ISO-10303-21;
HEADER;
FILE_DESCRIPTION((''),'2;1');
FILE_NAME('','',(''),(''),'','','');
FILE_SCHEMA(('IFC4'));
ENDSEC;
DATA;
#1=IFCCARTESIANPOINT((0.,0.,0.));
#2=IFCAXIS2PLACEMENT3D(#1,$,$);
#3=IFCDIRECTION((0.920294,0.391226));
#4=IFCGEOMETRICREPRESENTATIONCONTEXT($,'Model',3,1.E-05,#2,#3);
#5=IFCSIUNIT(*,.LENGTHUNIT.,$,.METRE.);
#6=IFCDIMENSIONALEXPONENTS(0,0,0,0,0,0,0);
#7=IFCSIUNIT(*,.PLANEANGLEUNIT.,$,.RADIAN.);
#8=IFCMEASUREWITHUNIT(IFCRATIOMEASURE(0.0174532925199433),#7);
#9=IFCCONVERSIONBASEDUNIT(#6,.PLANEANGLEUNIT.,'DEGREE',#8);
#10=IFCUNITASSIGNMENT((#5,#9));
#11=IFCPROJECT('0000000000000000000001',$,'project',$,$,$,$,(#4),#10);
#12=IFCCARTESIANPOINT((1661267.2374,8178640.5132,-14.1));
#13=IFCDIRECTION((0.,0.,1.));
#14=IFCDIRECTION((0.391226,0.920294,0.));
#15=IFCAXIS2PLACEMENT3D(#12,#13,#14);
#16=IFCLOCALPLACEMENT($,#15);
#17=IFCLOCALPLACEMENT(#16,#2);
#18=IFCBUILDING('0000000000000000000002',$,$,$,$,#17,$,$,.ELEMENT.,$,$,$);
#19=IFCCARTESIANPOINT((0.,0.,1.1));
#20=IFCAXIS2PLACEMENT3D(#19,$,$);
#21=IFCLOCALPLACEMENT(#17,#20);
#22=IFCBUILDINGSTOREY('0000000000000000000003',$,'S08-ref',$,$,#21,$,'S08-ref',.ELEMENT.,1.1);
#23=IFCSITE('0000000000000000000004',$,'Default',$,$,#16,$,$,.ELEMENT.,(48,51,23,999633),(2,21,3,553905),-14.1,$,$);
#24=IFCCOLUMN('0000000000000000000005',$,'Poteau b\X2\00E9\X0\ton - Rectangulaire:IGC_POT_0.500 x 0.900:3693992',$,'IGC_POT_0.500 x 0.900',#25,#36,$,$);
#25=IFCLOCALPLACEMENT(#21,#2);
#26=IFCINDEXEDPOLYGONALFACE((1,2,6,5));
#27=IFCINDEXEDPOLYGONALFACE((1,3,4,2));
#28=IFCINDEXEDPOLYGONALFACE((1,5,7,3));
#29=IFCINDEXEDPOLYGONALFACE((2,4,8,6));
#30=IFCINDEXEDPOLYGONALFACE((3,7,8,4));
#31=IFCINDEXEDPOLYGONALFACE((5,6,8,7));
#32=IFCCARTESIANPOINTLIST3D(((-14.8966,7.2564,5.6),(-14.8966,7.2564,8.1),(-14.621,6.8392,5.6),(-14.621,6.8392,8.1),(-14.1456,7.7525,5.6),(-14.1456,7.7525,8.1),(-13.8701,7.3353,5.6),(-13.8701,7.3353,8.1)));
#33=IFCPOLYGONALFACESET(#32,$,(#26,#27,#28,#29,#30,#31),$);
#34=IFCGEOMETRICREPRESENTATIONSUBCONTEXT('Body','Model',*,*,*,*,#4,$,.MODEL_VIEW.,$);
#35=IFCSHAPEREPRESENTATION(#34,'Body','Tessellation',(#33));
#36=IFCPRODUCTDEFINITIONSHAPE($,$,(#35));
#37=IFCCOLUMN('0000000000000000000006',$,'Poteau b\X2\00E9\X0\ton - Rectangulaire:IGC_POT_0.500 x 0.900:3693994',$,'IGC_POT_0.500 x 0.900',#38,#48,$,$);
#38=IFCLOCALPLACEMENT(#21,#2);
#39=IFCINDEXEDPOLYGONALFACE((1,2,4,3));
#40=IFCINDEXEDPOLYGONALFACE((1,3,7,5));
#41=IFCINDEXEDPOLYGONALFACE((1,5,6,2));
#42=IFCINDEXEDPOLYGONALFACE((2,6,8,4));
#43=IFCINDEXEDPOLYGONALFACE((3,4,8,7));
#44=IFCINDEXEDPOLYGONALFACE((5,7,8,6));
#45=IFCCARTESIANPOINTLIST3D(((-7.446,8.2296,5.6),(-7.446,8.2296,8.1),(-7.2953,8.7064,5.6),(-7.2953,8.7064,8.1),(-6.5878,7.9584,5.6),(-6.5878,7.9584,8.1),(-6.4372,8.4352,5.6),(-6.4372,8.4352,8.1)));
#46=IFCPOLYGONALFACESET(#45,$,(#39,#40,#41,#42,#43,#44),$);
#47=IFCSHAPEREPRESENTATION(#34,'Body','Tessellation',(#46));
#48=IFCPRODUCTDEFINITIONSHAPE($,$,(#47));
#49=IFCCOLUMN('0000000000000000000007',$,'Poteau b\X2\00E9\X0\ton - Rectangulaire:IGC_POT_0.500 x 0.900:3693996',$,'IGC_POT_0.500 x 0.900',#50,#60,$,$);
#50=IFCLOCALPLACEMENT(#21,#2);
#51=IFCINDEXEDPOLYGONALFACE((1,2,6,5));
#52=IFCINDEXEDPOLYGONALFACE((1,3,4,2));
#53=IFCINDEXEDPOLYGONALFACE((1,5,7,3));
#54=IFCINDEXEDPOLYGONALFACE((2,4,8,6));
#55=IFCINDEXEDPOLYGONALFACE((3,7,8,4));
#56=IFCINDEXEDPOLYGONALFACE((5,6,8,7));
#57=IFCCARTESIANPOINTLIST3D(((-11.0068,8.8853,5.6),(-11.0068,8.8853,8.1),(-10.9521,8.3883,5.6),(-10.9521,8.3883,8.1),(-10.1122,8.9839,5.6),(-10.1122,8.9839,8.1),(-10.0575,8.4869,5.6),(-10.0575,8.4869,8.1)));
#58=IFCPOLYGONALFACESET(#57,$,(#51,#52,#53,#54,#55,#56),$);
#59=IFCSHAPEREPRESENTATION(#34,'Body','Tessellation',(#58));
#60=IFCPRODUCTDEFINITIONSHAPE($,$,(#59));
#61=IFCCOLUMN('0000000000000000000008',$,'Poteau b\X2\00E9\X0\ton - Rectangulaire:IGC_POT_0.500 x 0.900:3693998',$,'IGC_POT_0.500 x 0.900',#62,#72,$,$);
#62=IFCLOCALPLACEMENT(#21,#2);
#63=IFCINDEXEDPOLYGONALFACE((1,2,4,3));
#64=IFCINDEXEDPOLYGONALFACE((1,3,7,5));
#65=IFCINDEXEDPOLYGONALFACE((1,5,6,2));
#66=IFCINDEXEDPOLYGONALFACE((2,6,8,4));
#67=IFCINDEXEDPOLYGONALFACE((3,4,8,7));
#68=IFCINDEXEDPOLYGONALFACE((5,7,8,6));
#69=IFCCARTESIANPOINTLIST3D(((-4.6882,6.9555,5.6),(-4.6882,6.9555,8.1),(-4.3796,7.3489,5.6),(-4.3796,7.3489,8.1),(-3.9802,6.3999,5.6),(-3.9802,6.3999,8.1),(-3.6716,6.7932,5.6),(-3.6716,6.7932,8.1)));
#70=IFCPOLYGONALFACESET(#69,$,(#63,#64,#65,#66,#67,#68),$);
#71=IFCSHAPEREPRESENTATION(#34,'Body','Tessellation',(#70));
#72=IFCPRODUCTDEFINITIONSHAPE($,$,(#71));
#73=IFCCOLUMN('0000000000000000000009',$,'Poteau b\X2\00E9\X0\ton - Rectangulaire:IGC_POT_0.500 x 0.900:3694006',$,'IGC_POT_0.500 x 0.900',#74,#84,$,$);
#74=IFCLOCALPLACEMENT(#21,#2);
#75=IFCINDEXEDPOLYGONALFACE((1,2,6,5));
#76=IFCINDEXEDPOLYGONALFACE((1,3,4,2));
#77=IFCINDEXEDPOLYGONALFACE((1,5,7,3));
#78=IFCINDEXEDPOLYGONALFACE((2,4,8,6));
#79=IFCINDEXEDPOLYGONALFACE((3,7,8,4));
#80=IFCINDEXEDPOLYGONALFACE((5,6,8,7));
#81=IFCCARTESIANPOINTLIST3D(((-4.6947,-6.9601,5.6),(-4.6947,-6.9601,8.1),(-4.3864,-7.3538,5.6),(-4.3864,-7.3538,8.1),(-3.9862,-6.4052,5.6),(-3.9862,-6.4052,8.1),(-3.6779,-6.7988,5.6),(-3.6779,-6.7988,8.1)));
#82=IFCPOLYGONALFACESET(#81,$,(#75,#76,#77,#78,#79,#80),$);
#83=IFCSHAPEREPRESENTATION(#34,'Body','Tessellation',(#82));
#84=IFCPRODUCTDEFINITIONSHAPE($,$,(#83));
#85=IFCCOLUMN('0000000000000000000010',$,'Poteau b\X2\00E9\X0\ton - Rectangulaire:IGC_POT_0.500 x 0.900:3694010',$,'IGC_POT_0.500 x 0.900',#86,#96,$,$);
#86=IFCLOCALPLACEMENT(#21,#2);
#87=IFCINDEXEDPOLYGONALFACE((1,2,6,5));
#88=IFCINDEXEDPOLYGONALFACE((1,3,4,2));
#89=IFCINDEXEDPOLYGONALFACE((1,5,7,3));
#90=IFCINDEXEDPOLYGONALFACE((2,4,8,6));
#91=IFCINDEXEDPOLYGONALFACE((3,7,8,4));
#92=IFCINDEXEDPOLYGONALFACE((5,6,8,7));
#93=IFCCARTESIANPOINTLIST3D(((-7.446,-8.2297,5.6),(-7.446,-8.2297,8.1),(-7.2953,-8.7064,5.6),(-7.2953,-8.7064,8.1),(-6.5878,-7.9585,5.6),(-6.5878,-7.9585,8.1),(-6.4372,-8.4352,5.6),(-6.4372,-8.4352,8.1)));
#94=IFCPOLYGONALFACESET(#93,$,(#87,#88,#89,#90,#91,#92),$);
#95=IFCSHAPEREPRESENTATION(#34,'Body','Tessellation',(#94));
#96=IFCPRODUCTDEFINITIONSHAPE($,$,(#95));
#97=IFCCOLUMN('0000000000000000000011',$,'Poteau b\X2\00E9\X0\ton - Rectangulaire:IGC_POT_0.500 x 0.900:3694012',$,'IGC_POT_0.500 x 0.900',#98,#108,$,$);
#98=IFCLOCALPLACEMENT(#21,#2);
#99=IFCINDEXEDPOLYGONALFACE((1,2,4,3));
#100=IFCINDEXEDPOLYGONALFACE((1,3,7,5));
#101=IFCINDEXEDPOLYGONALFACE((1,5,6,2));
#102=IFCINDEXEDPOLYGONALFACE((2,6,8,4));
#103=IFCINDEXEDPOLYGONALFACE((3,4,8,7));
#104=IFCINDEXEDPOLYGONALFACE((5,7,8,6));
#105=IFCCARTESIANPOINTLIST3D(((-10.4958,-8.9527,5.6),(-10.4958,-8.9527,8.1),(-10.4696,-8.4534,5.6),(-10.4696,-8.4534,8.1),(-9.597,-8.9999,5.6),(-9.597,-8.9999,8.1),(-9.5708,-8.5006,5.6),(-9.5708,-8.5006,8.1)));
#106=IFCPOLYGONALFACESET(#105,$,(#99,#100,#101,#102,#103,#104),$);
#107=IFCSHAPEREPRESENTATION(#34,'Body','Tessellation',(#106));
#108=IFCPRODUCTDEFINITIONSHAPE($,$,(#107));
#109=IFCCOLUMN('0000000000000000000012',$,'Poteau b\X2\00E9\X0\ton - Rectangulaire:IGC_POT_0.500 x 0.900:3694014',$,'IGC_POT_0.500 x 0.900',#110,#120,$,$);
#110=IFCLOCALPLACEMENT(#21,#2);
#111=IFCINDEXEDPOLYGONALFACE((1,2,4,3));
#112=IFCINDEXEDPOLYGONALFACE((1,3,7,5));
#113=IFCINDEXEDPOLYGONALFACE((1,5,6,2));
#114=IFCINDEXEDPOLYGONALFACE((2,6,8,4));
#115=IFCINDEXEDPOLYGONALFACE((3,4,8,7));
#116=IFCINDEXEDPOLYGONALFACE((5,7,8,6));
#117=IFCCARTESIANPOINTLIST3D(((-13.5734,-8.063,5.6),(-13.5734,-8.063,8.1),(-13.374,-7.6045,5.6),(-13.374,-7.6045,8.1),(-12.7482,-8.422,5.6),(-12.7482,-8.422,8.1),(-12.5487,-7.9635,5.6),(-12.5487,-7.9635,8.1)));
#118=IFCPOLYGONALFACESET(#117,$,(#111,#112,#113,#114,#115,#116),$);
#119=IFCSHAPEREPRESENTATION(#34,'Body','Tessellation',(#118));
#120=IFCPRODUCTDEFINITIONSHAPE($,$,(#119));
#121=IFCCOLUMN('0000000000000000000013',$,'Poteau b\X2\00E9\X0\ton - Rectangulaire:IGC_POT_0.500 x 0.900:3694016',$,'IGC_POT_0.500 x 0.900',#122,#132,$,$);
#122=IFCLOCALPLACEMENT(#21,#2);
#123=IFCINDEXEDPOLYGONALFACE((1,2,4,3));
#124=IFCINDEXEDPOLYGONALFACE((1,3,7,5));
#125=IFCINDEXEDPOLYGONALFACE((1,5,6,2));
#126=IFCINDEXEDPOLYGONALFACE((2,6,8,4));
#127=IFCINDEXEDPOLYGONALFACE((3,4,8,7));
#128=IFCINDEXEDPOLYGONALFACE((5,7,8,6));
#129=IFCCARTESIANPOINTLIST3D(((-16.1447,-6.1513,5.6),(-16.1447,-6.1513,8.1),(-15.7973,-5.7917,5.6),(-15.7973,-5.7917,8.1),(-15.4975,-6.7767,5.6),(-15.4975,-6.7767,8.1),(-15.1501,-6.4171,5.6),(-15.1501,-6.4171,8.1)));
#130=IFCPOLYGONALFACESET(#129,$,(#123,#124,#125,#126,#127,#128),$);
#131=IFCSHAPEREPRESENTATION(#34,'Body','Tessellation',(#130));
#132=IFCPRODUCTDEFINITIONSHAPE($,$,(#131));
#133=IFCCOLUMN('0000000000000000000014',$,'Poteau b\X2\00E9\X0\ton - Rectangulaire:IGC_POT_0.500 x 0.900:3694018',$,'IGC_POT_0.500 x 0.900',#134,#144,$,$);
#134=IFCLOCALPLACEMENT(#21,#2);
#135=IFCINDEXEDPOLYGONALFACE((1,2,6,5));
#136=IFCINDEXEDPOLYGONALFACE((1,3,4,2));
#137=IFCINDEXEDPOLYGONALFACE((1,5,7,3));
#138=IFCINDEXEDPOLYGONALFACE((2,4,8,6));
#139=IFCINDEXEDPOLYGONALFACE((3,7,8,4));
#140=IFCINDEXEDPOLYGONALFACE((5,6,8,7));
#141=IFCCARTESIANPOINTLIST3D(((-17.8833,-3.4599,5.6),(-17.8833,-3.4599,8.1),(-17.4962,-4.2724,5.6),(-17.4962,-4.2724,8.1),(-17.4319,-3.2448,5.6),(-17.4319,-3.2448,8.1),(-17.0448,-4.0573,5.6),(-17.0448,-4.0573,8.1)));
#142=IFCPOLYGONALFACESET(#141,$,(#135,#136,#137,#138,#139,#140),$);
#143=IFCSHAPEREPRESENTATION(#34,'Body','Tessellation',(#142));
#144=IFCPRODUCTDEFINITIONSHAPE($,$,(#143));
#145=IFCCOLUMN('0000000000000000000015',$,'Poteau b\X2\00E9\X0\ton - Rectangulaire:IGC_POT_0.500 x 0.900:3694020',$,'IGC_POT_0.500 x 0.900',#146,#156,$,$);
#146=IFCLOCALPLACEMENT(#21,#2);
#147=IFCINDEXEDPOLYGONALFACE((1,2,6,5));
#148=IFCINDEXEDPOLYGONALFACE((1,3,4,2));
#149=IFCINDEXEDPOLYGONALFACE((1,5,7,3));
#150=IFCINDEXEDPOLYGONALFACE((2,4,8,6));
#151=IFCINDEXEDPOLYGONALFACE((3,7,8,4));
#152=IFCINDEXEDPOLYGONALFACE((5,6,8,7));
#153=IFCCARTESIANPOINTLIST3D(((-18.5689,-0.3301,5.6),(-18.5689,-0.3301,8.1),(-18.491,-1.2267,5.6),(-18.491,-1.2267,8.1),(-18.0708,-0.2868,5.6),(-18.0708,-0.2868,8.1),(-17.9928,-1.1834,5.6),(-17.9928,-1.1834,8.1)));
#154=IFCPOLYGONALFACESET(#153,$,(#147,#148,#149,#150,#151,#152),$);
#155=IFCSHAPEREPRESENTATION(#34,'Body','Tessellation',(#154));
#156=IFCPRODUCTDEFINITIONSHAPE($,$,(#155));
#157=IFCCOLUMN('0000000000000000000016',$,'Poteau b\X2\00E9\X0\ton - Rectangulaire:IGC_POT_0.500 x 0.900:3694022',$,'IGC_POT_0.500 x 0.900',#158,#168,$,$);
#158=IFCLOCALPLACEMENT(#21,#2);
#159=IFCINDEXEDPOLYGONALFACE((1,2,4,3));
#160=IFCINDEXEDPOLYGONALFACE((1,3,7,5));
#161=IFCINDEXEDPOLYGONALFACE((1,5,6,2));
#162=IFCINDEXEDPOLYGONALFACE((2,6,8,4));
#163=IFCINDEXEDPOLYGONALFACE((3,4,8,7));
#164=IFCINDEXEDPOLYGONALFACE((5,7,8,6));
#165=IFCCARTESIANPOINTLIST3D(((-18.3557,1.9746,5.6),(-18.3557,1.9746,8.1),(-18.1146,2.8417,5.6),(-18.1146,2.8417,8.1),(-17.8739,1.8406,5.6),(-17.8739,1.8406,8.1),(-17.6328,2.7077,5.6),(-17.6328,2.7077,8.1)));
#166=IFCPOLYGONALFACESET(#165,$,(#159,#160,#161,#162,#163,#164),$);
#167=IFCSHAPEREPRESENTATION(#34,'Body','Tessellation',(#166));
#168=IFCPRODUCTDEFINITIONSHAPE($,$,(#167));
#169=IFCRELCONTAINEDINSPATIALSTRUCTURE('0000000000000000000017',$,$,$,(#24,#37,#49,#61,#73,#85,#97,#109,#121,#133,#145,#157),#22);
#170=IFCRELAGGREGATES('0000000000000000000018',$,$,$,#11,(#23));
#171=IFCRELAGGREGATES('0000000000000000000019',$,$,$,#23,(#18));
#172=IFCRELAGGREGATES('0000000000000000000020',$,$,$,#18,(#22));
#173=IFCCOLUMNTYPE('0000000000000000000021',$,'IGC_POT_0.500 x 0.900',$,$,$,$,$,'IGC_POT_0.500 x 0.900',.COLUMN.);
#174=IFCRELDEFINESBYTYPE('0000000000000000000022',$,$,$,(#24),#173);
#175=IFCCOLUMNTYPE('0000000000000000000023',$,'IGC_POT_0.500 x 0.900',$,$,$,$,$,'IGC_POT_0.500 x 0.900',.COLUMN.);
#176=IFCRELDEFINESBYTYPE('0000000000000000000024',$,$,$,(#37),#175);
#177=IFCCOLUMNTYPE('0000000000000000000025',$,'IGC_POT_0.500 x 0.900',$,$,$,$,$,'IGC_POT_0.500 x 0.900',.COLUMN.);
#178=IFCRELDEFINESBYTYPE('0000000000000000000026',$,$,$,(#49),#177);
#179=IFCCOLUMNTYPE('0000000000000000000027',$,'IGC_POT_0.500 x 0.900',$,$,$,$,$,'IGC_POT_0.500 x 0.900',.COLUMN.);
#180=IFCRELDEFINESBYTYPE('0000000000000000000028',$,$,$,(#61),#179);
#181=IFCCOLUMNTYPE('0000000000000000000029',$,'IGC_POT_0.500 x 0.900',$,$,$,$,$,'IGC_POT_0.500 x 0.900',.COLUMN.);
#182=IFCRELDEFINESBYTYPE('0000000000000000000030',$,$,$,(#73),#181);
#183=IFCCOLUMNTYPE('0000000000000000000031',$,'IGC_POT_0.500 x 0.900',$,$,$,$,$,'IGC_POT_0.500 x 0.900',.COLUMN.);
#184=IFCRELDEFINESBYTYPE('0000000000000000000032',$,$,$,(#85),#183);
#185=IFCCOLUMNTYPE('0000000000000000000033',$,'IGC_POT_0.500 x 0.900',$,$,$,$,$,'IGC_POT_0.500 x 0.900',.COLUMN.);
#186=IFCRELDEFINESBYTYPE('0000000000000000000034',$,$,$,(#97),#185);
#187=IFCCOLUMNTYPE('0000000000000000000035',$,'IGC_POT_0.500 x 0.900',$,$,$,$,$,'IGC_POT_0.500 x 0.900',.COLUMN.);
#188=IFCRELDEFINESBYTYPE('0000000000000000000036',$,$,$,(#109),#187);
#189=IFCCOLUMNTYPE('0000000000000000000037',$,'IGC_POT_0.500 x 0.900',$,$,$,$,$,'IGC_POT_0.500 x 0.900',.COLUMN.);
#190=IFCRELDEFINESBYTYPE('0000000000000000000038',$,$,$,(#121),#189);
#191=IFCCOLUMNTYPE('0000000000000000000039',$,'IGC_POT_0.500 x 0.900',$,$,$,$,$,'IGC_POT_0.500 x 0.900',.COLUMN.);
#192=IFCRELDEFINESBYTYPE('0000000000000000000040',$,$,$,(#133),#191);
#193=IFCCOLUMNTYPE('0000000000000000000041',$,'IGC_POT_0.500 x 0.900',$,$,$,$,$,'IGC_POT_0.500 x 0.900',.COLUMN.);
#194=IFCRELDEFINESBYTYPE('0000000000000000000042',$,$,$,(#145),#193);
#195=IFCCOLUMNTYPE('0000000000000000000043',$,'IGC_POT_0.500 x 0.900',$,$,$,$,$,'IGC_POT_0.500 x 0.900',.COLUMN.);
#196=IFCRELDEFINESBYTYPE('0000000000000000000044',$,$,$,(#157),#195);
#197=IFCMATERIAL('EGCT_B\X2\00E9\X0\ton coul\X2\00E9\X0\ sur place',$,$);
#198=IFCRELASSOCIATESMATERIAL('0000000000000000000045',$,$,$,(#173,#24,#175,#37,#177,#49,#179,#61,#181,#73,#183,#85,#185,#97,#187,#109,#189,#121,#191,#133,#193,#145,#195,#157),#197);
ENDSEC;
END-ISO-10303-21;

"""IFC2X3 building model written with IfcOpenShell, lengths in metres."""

from ifc_helpers import new_model, entity, si_unit, converted_unit, direction, frame, frame_2d, origin, origin_2d_with_axis, place, context, subcontext, project, spatial, rectangle, extrude, source, transform, mapped, material, type_object, type_shapes, element, save


model = new_model("IFC2X3")

# Units and contexts
model_context = context("Model", 3, precision=1e-05, world=origin(), true_north=direction((0.920294, 0.391226)))
body_context = subcontext(model_context, "Body", "Model", "MODEL_VIEW")
ifc_project = project(units=[si_unit("LENGTHUNIT", "METRE"), converted_unit("PLANEANGLEUNIT", "DEGREE", entity("IfcRatioMeasure", 0.0174532925199433), si_unit("PLANEANGLEUNIT", "RADIAN"), dimensions=[0, 0, 0, 0, 0, 0, 0])], contexts=[model_context])

# Site, building, storey
site_placement = place(None, frame((1661267.2374, 8178640.5132, -14.1), z_axis=(0.0, 0.0, 1.0), x_axis=(0.391226, 0.920294, 0.0)))
site = spatial("IfcSite", under=ifc_project, at=site_placement, Name="Default", CompositionType="ELEMENT", RefLatitude=(48, 51, 23, 999633), RefLongitude=(2, 21, 3, 553905), RefElevation=-14.1)
building_placement = place(site_placement, origin())
building = spatial("IfcBuilding", under=site, at=building_placement, CompositionType="ELEMENT")
storey_placement = place(building_placement, frame((0.0, 0.0, 1.1)))
storey = spatial("IfcBuildingStorey", under=building, at=storey_placement, Name="S08-ref", LongName="S08-ref", CompositionType="ELEMENT", Elevation=1.1)

# Columns
ifc_material_1 = material(Name="EGCT_Béton coulé sur place")
column_type_1 = type_object("IfcColumnType", Name="IGC_POT_0.500 x 0.900", ElementType="IGC_POT_0.500 x 0.900", PredefinedType="COLUMN", material=ifc_material_1)
shared_shape_1 = source(origin(), body_context, "Body", "SweptSolid", [
    extrude(rectangle(XDim=0.5, YDim=0.9, at=origin_2d_with_axis()), frame((-14.3833, 7.2959, 6.7), z_axis=(0.0, 0.0, 1.0), x_axis=(-0.551164, 0.834397, 0.0)), (0.0, 0.0, 1.0), 2.5),
])
type_shapes(column_type_1, [shared_shape_1])
column_1_placement = place(storey_placement, frame((0.0, 0.0, -1.1)))
element("IfcColumn", 1, at=column_1_placement, inside=storey, type_object=column_type_1, material=ifc_material_1, Name="Poteau béton - Rectangulaire:IGC_POT_0.500 x 0.900:3693992", ObjectType="IGC_POT_0.500 x 0.900", context=body_context, shape_type="MappedRepresentation", body=[
    mapped(shared_shape_1, transform((0.0, 0.0, 0.0), scale=1.0)),
])
column_type_2 = type_object("IfcColumnType", Name="IGC_POT_0.500 x 0.900", ElementType="IGC_POT_0.500 x 0.900", PredefinedType="COLUMN", material=ifc_material_1)
shared_shape_2 = source(origin(), body_context, "Body", "SweptSolid", [
    extrude(rectangle(XDim=0.9, YDim=0.5, at=origin_2d_with_axis()), frame((-6.9416, 8.3324, 6.7), z_axis=(0.0, 0.0, 1.0), x_axis=(-0.953513, 0.301352, 0.0)), (0.0, 0.0, 1.0), 2.5),
])
type_shapes(column_type_2, [shared_shape_2])
column_2_placement = place(storey_placement, frame((0.0, 0.0, -1.1)))
element("IfcColumn", 2, at=column_2_placement, inside=storey, type_object=column_type_2, material=ifc_material_1, Name="Poteau béton - Rectangulaire:IGC_POT_0.500 x 0.900:3693994", ObjectType="IGC_POT_0.500 x 0.900", context=body_context, shape_type="MappedRepresentation", body=[
    mapped(shared_shape_2, transform((0.0, 0.0, 0.0), scale=1.0)),
])
column_type_3 = type_object("IfcColumnType", Name="IGC_POT_0.500 x 0.900", ElementType="IGC_POT_0.500 x 0.900", PredefinedType="COLUMN", material=ifc_material_1)
shared_shape_3 = source(origin(), body_context, "Body", "SweptSolid", [
    extrude(rectangle(XDim=0.9, YDim=0.5, at=frame_2d((0.0, 0.0), x_axis=(1.0, 0.0))), frame((-10.5321, 8.6861, 6.7), z_axis=(0.0, 0.0, 1.0), x_axis=(-0.993983, -0.10953, 0.0)), (0.0, 0.0, 1.0), 2.5),
])
type_shapes(column_type_3, [shared_shape_3])
column_3_placement = place(storey_placement, frame((0.0, 0.0, -1.1)))
element("IfcColumn", 3, at=column_3_placement, inside=storey, type_object=column_type_3, material=ifc_material_1, Name="Poteau béton - Rectangulaire:IGC_POT_0.500 x 0.900:3693996", ObjectType="IGC_POT_0.500 x 0.900", context=body_context, shape_type="MappedRepresentation", body=[
    mapped(shared_shape_3, transform((0.0, 0.0, 0.0), scale=1.0)),
])
column_type_4 = type_object("IfcColumnType", Name="IGC_POT_0.500 x 0.900", ElementType="IGC_POT_0.500 x 0.900", PredefinedType="COLUMN", material=ifc_material_1)
shared_shape_4 = source(origin(), body_context, "Body", "SweptSolid", [
    extrude(rectangle(XDim=0.9, YDim=0.5, at=frame_2d((0.0, 0.0), x_axis=(1.0, 0.0))), frame((-4.1799, 6.8744, 6.7), z_axis=(0.0, 0.0, 1.0), x_axis=(-0.786665, 0.617381, 0.0)), (0.0, 0.0, 1.0), 2.5),
])
type_shapes(column_type_4, [shared_shape_4])
column_4_placement = place(storey_placement, frame((0.0, 0.0, -1.1)))
element("IfcColumn", 4, at=column_4_placement, inside=storey, type_object=column_type_4, material=ifc_material_1, Name="Poteau béton - Rectangulaire:IGC_POT_0.500 x 0.900:3693998", ObjectType="IGC_POT_0.500 x 0.900", context=body_context, shape_type="MappedRepresentation", body=[
    mapped(shared_shape_4, transform((0.0, 0.0, 0.0), scale=1.0)),
])
column_type_5 = type_object("IfcColumnType", Name="IGC_POT_0.500 x 0.900", ElementType="IGC_POT_0.500 x 0.900", PredefinedType="COLUMN", material=ifc_material_1)
shared_shape_5 = source(origin(), body_context, "Body", "SweptSolid", [
    extrude(rectangle(XDim=0.9, YDim=0.5, at=origin_2d_with_axis()), frame((-4.1863, -6.8795, 6.7), z_axis=(0.0, 0.0, 1.0), x_axis=(0.787239, 0.616648, 0.0)), (0.0, 0.0, 1.0), 2.5),
])
type_shapes(column_type_5, [shared_shape_5])
column_5_placement = place(storey_placement, frame((0.0, 0.0, -1.1)))
element("IfcColumn", 5, at=column_5_placement, inside=storey, type_object=column_type_5, material=ifc_material_1, Name="Poteau béton - Rectangulaire:IGC_POT_0.500 x 0.900:3694006", ObjectType="IGC_POT_0.500 x 0.900", context=body_context, shape_type="MappedRepresentation", body=[
    mapped(shared_shape_5, transform((0.0, 0.0, 0.0), scale=1.0)),
])
column_type_6 = type_object("IfcColumnType", Name="IGC_POT_0.500 x 0.900", ElementType="IGC_POT_0.500 x 0.900", PredefinedType="COLUMN", material=ifc_material_1)
shared_shape_6 = source(origin(), body_context, "Body", "SweptSolid", [
    extrude(rectangle(XDim=0.5, YDim=0.9, at=origin_2d_with_axis()), frame((-6.9416, -8.3325, 6.7), z_axis=(0.0, 0.0, 1.0), x_axis=(-0.301353, 0.953513, 0.0)), (0.0, 0.0, 1.0), 2.5),
])
type_shapes(column_type_6, [shared_shape_6])
column_6_placement = place(storey_placement, frame((0.0, 0.0, -1.1)))
element("IfcColumn", 6, at=column_6_placement, inside=storey, type_object=column_type_6, material=ifc_material_1, Name="Poteau béton - Rectangulaire:IGC_POT_0.500 x 0.900:3694010", ObjectType="IGC_POT_0.500 x 0.900", context=body_context, shape_type="MappedRepresentation", body=[
    mapped(shared_shape_6, transform((0.0, 0.0, 0.0), scale=1.0)),
])
column_type_7 = type_object("IfcColumnType", Name="IGC_POT_0.500 x 0.900", ElementType="IGC_POT_0.500 x 0.900", PredefinedType="COLUMN", material=ifc_material_1)
shared_shape_7 = source(origin(), body_context, "Body", "SweptSolid", [
    extrude(rectangle(XDim=0.5, YDim=0.9, at=frame_2d((0.0, 0.0), x_axis=(1.0, 0.0))), frame((-10.0333, -8.7267, 6.7), z_axis=(0.0, 0.0, 1.0), x_axis=(0.052447, 0.998624, 0.0)), (0.0, 0.0, 1.0), 2.5),
])
type_shapes(column_type_7, [shared_shape_7])
column_7_placement = place(storey_placement, frame((0.0, 0.0, -1.1)))
element("IfcColumn", 7, at=column_7_placement, inside=storey, type_object=column_type_7, material=ifc_material_1, Name="Poteau béton - Rectangulaire:IGC_POT_0.500 x 0.900:3694012", ObjectType="IGC_POT_0.500 x 0.900", context=body_context, shape_type="MappedRepresentation", body=[
    mapped(shared_shape_7, transform((0.0, 0.0, 0.0), scale=1.0)),
])
column_type_8 = type_object("IfcColumnType", Name="IGC_POT_0.500 x 0.900", ElementType="IGC_POT_0.500 x 0.900", PredefinedType="COLUMN", material=ifc_material_1)
shared_shape_8 = source(origin(), body_context, "Body", "SweptSolid", [
    extrude(rectangle(XDim=0.9, YDim=0.5, at=frame_2d((0.0, 0.0), x_axis=(1.0, 0.0))), frame((-13.0611, -8.0132, 6.7), z_axis=(0.0, 0.0, 1.0), x_axis=(-0.916984, 0.398923, 0.0)), (0.0, 0.0, 1.0), 2.5),
])
type_shapes(column_type_8, [shared_shape_8])
column_8_placement = place(storey_placement, frame((0.0, 0.0, -1.1)))
element("IfcColumn", 8, at=column_8_placement, inside=storey, type_object=column_type_8, material=ifc_material_1, Name="Poteau béton - Rectangulaire:IGC_POT_0.500 x 0.900:3694014", ObjectType="IGC_POT_0.500 x 0.900", context=body_context, shape_type="MappedRepresentation", body=[
    mapped(shared_shape_8, transform((0.0, 0.0, 0.0), scale=1.0)),
])
column_type_9 = type_object("IfcColumnType", Name="IGC_POT_0.500 x 0.900", ElementType="IGC_POT_0.500 x 0.900", PredefinedType="COLUMN", material=ifc_material_1)
shared_shape_9 = source(origin(), body_context, "Body", "SweptSolid", [
    extrude(rectangle(XDim=0.9, YDim=0.5, at=origin_2d_with_axis()), frame((-15.6474, -6.2842, 6.7), z_axis=(0.0, 0.0, 1.0), x_axis=(-0.719121, 0.694885, 0.0)), (0.0, 0.0, 1.0), 2.5),
])
type_shapes(column_type_9, [shared_shape_9])
column_9_placement = place(storey_placement, frame((0.0, 0.0, -1.1)))
element("IfcColumn", 9, at=column_9_placement, inside=storey, type_object=column_type_9, material=ifc_material_1, Name="Poteau béton - Rectangulaire:IGC_POT_0.500 x 0.900:3694016", ObjectType="IGC_POT_0.500 x 0.900", context=body_context, shape_type="MappedRepresentation", body=[
    mapped(shared_shape_9, transform((0.0, 0.0, 0.0), scale=1.0)),
])
column_type_10 = type_object("IfcColumnType", Name="IGC_POT_0.500 x 0.900", ElementType="IGC_POT_0.500 x 0.900", PredefinedType="COLUMN", material=ifc_material_1)
shared_shape_10 = source(origin(), body_context, "Body", "SweptSolid", [
    extrude(rectangle(XDim=0.9, YDim=0.5, at=frame_2d((0.0, 0.0), x_axis=(1.0, 0.0))), frame((-17.4641, -3.7586, 6.7), z_axis=(0.0, 0.0, 1.0), x_axis=(-0.430108, 0.902777, 0.0)), (0.0, 0.0, 1.0), 2.5),
])
type_shapes(column_type_10, [shared_shape_10])
column_10_placement = place(storey_placement, frame((0.0, 0.0, -1.1)))
element("IfcColumn", 10, at=column_10_placement, inside=storey, type_object=column_type_10, material=ifc_material_1, Name="Poteau béton - Rectangulaire:IGC_POT_0.500 x 0.900:3694018", ObjectType="IGC_POT_0.500 x 0.900", context=body_context, shape_type="MappedRepresentation", body=[
    mapped(shared_shape_10, transform((0.0, 0.0, 0.0), scale=1.0)),
])
column_type_11 = type_object("IfcColumnType", Name="IGC_POT_0.500 x 0.900", ElementType="IGC_POT_0.500 x 0.900", PredefinedType="COLUMN", material=ifc_material_1)
shared_shape_11 = source(origin(), body_context, "Body", "SweptSolid", [
    extrude(rectangle(XDim=0.9, YDim=0.5, at=frame_2d((0.0, 0.0), x_axis=(1.0, 0.0))), frame((-18.2809, -0.7567, 6.7), z_axis=(0.0, 0.0, 1.0), x_axis=(-0.086594, 0.996244, 0.0)), (0.0, 0.0, 1.0), 2.5),
])
type_shapes(column_type_11, [shared_shape_11])
column_11_placement = place(storey_placement, frame((0.0, 0.0, -1.1)))
element("IfcColumn", 11, at=column_11_placement, inside=storey, type_object=column_type_11, material=ifc_material_1, Name="Poteau béton - Rectangulaire:IGC_POT_0.500 x 0.900:3694020", ObjectType="IGC_POT_0.500 x 0.900", context=body_context, shape_type="MappedRepresentation", body=[
    mapped(shared_shape_11, transform((0.0, 0.0, 0.0), scale=1.0)),
])
column_type_12 = type_object("IfcColumnType", Name="IGC_POT_0.500 x 0.900", ElementType="IGC_POT_0.500 x 0.900", PredefinedType="COLUMN", material=ifc_material_1)
shared_shape_12 = source(origin(), body_context, "Body", "SweptSolid", [
    extrude(rectangle(XDim=0.5, YDim=0.9, at=frame_2d((0.0, 0.0), x_axis=(1.0, 0.0))), frame((-17.9943, 2.3411, 6.7), z_axis=(0.0, 0.0, 1.0), x_axis=(-0.963446, 0.267904, 0.0)), (0.0, 0.0, 1.0), 2.5),
])
type_shapes(column_type_12, [shared_shape_12])
column_12_placement = place(storey_placement, frame((0.0, 0.0, -1.1)))
element("IfcColumn", 12, at=column_12_placement, inside=storey, type_object=column_type_12, material=ifc_material_1, Name="Poteau béton - Rectangulaire:IGC_POT_0.500 x 0.900:3694022", ObjectType="IGC_POT_0.500 x 0.900", context=body_context, shape_type="MappedRepresentation", body=[
    mapped(shared_shape_12, transform((0.0, 0.0, 0.0), scale=1.0)),
])

save(model, "model.ifc")
